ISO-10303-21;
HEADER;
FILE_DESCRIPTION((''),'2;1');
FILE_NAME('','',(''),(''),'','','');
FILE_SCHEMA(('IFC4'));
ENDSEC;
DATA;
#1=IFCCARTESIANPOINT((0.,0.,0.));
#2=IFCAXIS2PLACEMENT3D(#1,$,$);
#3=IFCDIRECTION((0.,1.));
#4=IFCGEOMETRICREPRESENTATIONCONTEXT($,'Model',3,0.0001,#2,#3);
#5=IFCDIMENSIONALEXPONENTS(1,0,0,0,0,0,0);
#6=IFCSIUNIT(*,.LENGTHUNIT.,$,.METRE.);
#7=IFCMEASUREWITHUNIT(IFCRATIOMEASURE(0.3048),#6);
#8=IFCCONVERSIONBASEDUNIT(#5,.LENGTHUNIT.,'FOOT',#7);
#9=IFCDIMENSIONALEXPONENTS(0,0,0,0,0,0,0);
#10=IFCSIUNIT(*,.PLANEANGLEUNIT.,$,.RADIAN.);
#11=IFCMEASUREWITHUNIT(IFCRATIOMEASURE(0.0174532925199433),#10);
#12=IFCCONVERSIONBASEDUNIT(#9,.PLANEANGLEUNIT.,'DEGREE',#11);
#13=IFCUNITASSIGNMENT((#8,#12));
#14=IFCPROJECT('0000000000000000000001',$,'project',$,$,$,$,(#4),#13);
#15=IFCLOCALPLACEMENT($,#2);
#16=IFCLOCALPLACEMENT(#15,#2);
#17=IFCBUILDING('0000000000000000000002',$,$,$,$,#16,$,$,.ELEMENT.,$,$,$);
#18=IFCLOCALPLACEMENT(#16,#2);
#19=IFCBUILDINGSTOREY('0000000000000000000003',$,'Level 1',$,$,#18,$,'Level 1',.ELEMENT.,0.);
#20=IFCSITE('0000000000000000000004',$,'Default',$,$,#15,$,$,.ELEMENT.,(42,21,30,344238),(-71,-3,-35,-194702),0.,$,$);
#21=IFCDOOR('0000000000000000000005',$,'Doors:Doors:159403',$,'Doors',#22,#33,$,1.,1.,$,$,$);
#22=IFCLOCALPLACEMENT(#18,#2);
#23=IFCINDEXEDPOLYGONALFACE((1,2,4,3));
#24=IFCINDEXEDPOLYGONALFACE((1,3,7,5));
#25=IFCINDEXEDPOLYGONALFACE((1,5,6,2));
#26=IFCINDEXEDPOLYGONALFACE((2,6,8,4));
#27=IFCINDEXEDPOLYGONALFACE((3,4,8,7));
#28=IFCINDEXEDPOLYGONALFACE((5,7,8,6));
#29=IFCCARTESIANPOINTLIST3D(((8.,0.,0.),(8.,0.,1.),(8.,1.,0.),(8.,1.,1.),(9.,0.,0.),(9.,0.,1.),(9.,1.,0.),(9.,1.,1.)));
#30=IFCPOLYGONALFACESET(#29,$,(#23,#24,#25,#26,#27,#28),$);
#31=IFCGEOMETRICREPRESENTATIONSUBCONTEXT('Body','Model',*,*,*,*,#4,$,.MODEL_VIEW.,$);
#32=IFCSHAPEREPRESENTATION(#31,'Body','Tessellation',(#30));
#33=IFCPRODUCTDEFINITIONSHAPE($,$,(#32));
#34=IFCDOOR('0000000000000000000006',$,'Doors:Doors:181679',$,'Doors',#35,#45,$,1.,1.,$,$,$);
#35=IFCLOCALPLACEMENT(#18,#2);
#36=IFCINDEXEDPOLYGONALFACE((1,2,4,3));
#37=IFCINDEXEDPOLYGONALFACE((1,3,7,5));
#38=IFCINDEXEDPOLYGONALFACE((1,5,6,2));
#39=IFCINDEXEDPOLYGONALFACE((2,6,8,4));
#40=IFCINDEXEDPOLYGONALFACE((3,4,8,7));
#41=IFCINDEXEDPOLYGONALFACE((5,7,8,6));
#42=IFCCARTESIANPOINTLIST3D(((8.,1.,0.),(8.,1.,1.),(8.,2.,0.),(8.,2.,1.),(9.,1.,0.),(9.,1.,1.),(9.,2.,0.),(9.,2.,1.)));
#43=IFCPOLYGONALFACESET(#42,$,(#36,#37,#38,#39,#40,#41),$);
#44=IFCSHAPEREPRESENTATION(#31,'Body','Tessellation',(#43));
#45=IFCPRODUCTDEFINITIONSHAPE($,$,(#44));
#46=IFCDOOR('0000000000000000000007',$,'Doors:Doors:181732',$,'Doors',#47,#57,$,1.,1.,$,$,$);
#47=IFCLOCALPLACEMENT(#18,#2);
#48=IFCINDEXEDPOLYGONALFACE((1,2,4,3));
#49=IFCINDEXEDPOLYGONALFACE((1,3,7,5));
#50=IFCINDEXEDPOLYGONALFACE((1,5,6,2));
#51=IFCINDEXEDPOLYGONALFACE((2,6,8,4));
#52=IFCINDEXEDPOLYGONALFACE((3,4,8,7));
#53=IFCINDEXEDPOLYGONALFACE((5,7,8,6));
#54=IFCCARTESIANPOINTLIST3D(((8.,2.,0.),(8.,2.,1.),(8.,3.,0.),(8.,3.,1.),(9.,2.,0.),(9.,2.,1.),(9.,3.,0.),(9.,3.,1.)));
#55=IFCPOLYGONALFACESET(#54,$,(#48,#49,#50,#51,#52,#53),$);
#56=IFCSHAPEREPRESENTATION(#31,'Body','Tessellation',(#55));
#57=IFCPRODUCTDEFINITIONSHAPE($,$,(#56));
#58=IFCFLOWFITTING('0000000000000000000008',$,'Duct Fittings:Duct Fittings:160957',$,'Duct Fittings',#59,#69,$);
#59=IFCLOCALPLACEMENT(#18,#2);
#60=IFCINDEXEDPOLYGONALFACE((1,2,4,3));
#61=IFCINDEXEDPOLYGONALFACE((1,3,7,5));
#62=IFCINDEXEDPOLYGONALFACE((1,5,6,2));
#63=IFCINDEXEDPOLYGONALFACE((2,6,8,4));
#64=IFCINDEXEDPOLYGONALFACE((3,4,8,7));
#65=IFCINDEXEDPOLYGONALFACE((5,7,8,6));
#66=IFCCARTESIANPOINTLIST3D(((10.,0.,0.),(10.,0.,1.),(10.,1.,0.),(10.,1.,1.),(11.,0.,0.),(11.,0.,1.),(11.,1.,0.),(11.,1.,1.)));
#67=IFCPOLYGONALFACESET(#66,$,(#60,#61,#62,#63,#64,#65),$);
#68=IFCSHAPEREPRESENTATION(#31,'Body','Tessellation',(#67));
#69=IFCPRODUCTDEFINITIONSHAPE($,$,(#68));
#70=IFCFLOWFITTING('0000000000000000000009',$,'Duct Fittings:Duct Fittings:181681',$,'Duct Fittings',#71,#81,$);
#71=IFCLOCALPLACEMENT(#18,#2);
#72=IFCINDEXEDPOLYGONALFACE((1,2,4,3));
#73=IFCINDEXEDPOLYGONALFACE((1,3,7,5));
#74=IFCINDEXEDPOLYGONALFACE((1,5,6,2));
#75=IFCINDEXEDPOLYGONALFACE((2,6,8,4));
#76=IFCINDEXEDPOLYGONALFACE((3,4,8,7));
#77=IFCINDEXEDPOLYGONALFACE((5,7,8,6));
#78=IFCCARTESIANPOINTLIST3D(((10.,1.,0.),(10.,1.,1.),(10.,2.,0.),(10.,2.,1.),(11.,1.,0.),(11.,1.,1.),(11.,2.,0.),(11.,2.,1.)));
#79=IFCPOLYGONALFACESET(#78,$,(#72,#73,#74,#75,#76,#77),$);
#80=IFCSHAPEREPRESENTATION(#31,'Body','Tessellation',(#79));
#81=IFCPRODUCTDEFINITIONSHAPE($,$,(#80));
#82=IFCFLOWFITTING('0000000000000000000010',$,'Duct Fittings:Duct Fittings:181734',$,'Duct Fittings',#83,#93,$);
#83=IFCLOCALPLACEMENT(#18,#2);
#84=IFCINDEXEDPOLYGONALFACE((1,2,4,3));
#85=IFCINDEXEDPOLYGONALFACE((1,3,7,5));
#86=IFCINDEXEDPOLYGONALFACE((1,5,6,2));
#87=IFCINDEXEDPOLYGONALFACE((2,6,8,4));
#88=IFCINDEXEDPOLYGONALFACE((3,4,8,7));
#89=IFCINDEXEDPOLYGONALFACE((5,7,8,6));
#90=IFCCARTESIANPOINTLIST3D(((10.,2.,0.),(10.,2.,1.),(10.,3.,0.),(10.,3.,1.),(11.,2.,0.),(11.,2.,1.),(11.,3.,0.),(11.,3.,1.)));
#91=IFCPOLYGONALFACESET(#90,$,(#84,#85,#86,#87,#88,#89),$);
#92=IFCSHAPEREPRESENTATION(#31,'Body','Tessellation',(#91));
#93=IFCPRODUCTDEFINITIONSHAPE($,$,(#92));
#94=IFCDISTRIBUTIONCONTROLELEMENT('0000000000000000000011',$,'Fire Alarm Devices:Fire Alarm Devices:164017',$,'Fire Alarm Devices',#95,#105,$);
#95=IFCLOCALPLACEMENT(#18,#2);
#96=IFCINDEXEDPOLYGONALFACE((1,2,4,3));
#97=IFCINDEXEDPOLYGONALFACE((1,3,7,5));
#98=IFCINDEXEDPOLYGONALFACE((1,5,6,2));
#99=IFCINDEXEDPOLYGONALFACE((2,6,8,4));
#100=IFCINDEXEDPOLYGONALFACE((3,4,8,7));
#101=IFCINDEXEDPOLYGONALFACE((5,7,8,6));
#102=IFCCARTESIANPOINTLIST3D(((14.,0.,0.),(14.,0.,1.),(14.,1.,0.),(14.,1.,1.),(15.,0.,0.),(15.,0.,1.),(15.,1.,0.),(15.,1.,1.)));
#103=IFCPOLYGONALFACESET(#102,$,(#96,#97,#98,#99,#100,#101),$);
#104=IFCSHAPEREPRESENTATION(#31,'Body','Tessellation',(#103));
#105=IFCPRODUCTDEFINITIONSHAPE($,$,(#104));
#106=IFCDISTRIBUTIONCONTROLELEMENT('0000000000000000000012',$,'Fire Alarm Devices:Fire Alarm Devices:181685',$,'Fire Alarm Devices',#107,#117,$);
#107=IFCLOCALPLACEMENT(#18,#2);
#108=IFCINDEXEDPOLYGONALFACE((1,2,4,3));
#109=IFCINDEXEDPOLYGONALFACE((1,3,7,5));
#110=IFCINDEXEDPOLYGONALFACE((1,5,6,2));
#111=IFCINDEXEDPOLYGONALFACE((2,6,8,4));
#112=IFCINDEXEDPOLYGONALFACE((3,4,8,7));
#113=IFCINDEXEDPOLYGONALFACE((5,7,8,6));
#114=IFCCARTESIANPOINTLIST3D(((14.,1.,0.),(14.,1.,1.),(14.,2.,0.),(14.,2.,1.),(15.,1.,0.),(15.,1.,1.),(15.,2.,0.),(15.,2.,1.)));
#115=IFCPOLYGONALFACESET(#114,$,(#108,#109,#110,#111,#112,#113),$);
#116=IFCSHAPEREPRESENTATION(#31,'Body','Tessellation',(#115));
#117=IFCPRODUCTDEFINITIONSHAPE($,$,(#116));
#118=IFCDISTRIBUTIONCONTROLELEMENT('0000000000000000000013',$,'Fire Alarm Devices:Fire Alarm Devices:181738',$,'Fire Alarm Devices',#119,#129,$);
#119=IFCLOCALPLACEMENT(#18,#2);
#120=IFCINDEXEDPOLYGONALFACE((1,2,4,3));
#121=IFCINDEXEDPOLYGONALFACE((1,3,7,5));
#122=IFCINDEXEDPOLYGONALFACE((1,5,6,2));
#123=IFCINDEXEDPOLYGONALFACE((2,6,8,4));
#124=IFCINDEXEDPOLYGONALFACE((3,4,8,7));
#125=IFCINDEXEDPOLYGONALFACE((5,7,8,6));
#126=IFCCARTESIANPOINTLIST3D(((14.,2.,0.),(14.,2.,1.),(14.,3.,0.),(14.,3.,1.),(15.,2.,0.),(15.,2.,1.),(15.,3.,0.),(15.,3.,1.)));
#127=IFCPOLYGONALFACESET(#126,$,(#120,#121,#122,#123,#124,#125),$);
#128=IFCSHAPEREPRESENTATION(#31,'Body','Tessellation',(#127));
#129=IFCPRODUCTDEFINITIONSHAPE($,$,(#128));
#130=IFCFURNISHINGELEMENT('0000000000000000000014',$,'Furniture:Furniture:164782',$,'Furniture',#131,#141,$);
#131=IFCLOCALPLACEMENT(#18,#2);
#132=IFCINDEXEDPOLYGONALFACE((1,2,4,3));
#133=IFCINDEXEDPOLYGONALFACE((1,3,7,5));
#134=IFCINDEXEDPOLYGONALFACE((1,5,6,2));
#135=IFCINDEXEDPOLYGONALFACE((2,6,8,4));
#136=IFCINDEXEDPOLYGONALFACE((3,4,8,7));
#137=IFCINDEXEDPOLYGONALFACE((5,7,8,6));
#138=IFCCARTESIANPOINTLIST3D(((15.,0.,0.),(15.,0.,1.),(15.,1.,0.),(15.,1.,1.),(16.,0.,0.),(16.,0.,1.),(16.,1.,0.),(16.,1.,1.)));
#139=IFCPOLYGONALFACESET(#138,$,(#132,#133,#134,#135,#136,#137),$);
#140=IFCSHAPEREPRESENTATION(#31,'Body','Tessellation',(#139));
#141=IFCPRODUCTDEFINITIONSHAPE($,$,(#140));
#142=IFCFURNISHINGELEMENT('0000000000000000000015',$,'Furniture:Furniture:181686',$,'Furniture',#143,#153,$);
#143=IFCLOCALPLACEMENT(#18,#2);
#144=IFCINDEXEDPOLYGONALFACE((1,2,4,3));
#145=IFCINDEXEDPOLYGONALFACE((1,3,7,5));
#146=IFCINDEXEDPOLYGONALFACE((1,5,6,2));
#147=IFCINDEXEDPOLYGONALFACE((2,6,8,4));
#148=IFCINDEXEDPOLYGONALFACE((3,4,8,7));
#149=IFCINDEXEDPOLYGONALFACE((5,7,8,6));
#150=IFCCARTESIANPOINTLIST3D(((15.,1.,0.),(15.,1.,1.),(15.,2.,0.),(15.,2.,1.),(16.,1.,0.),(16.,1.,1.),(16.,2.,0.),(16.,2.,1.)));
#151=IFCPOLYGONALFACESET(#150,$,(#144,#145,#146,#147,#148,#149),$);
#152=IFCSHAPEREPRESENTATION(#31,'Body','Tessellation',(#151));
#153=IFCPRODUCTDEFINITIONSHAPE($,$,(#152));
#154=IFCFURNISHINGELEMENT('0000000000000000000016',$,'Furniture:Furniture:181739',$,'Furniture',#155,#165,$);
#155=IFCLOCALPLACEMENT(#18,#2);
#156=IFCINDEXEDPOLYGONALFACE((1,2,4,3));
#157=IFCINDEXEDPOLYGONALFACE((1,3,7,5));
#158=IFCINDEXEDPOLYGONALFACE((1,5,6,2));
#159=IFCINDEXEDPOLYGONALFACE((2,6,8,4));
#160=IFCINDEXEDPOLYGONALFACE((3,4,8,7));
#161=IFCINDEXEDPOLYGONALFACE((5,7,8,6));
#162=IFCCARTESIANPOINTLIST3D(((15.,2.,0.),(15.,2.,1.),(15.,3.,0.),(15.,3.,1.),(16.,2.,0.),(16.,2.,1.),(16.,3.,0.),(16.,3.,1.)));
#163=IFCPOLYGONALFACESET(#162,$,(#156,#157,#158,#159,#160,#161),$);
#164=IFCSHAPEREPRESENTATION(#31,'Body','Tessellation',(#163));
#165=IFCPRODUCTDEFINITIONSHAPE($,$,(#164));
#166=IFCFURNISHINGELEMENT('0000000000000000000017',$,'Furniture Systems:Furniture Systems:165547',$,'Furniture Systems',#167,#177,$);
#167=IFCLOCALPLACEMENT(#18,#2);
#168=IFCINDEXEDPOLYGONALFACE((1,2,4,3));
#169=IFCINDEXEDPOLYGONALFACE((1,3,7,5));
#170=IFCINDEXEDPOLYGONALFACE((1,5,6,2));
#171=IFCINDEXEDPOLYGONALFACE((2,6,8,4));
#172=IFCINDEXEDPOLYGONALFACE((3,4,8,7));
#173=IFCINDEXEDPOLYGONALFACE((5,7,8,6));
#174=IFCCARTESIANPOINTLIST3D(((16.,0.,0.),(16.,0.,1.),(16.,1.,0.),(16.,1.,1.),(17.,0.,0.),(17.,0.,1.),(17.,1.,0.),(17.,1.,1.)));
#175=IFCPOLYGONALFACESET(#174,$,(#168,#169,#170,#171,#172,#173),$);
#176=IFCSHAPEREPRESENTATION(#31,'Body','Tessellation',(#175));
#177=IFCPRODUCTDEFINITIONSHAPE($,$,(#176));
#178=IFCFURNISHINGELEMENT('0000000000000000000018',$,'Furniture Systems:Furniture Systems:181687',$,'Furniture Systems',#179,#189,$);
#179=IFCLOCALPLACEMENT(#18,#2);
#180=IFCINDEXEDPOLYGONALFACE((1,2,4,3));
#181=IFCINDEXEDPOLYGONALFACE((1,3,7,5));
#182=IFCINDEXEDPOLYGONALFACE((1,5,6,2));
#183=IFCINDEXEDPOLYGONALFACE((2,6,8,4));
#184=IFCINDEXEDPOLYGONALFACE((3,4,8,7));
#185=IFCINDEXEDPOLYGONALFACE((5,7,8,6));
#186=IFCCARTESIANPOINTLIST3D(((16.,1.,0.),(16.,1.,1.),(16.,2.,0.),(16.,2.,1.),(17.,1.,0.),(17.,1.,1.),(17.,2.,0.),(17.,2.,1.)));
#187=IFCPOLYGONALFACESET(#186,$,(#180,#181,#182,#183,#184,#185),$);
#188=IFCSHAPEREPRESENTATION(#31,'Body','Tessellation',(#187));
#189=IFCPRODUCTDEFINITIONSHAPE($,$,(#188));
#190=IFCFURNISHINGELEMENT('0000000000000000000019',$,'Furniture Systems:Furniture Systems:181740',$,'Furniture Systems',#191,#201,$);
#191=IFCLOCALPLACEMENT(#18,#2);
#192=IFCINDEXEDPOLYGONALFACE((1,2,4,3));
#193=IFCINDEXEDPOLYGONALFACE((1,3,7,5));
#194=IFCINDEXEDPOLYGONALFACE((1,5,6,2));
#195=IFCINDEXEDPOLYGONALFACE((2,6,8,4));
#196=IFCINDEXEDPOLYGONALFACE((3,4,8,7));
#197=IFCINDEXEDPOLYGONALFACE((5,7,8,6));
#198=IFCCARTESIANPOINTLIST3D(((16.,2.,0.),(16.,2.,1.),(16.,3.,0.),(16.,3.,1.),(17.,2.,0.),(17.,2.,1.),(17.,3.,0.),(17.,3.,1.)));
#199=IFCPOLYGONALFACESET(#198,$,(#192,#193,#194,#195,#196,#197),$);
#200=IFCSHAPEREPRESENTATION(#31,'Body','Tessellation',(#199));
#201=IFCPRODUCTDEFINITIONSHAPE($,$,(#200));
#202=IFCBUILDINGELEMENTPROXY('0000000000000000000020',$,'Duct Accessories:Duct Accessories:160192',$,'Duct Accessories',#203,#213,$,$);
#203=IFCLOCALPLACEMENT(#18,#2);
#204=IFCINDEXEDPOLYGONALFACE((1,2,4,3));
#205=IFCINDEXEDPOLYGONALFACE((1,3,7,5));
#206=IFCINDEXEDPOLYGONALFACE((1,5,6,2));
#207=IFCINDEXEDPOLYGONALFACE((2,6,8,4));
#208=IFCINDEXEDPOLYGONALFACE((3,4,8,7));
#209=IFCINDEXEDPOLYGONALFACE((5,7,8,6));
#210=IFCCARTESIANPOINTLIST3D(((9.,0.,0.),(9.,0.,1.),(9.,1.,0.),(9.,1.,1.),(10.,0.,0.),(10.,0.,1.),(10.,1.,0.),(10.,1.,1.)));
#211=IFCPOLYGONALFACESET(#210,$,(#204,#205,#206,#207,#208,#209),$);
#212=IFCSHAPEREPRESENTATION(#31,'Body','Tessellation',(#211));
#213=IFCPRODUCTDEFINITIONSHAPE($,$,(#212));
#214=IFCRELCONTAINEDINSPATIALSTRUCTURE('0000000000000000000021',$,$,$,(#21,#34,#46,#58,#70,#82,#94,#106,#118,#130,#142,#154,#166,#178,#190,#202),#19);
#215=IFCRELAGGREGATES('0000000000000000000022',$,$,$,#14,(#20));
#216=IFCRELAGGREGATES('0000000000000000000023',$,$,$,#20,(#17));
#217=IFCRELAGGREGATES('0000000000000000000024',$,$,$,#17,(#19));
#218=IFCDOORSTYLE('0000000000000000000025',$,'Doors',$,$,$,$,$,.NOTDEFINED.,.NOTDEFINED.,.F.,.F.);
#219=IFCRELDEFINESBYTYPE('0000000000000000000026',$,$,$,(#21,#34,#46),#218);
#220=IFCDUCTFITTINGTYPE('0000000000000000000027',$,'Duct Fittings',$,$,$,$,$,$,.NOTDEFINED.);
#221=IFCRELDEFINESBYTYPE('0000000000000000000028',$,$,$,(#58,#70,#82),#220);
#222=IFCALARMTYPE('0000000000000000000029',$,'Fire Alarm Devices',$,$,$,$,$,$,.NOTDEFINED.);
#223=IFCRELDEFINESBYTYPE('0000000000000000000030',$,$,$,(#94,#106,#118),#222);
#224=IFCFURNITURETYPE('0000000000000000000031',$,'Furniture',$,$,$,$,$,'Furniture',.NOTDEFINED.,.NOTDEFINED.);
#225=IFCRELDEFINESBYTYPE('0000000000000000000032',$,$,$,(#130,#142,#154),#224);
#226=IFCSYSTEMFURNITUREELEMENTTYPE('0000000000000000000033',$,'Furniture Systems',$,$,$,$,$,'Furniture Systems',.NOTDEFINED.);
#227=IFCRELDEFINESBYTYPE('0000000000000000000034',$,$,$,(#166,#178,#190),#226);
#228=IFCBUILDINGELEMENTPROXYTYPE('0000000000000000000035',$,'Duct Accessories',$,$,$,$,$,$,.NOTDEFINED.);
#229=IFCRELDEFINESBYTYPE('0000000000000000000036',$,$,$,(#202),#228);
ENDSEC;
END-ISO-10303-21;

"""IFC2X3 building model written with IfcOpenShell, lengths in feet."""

from ifc_helpers import new_model, entity, si_unit, converted_unit, direction, frame, frame_2d, origin, place, context, subcontext, project, spatial, rectangle, extrude, source, transform, mapped, type_object, type_shapes, element, save


model = new_model("IFC2X3")

# Units and contexts
model_context = context("Model", 3, precision=0.0001, world=origin(), true_north=direction((0.0, 1.0)))
body_context = subcontext(model_context, "Body", "Model", "MODEL_VIEW")
ifc_project = project(units=[converted_unit("LENGTHUNIT", "FOOT", entity("IfcRatioMeasure", 0.3048), si_unit("LENGTHUNIT", "METRE"), dimensions=[1, 0, 0, 0, 0, 0, 0]), converted_unit("PLANEANGLEUNIT", "DEGREE", entity("IfcRatioMeasure", 0.0174532925199433), si_unit("PLANEANGLEUNIT", "RADIAN"), dimensions=[0, 0, 0, 0, 0, 0, 0])], contexts=[model_context])

# Site, building, storey
site_placement = place(None, origin())
site = spatial("IfcSite", under=ifc_project, at=site_placement, Name="Default", CompositionType="ELEMENT", RefLatitude=(42, 21, 30, 344238), RefLongitude=(-71, -3, -35, -194702), RefElevation=0.0)
building_placement = place(site_placement, origin())
building = spatial("IfcBuilding", under=site, at=building_placement, CompositionType="ELEMENT")
storey_placement = place(building_placement, origin())
storey = spatial("IfcBuildingStorey", under=building, at=storey_placement, Name="Level 1", LongName="Level 1", CompositionType="ELEMENT", Elevation=0.0)

# Doors
door_style = type_object("IfcDoorStyle", Name="Doors", ConstructionType="NOTDEFINED", OperationType="NOTDEFINED", ParameterTakesPrecedence=False, Sizeable=False)
shared_shape_1 = source(origin(), body_context, "Body", "SweptSolid", [
    extrude(rectangle(XDim=1.0, YDim=1.0, at=frame_2d((0.0, 0.0), x_axis=(1.0, 0.0))), frame((0.5, 0.5, 0.0), z_axis=(0.0, 0.0, 1.0), x_axis=(0.0, 1.0, 0.0)), (0.0, 0.0, 1.0), 1.0),
])
type_shapes(door_style, [shared_shape_1])
for number, where, name in (
    (1, (8.0, 0.0, 0.0), "Doors:Doors:159403"),
    (2, (8.0, 1.0, 0.0), "Doors:Doors:181679"),
    (3, (8.0, 2.0, 0.0), "Doors:Doors:181732"),
):
    element("IfcDoor", number, at=place(storey_placement, frame(where)), inside=storey, type_object=door_style, Name=name, ObjectType="Doors", OverallHeight=1.0, OverallWidth=1.0, context=body_context, shape_type="MappedRepresentation", body=[
        mapped(shared_shape_1, transform((0.0, 0.0, 0.0), scale=1.0)),
    ])

# Flow fittings
duct_fitting_type = type_object("IfcDuctFittingType", Name="Duct Fittings", PredefinedType="NOTDEFINED")
shared_shape_2 = source(origin(), body_context, "Body", "SweptSolid", [
    extrude(rectangle(XDim=1.0, YDim=1.0, at=frame_2d((0.0, 0.0), x_axis=(1.0, 0.0))), frame((0.5, 0.5, 0.0), z_axis=(0.0, 0.0, 1.0), x_axis=(0.0, 1.0, 0.0)), (0.0, 0.0, 1.0), 1.0),
])
type_shapes(duct_fitting_type, [shared_shape_2])
for number, where, name in (
    (4, (10.0, 0.0, 0.0), "Duct Fittings:Duct Fittings:160957"),
    (5, (10.0, 1.0, 0.0), "Duct Fittings:Duct Fittings:181681"),
    (6, (10.0, 2.0, 0.0), "Duct Fittings:Duct Fittings:181734"),
):
    element("IfcFlowFitting", number, at=place(storey_placement, frame(where)), inside=storey, type_object=duct_fitting_type, Name=name, ObjectType="Duct Fittings", context=body_context, shape_type="MappedRepresentation", body=[
        mapped(shared_shape_2, transform((0.0, 0.0, 0.0), scale=1.0)),
    ])

# Distribution control elements
alarm_type = type_object("IfcAlarmType", Name="Fire Alarm Devices", PredefinedType="NOTDEFINED")
shared_shape_3 = source(origin(), body_context, "Body", "SweptSolid", [
    extrude(rectangle(XDim=1.0, YDim=1.0, at=frame_2d((0.0, 0.0), x_axis=(1.0, 0.0))), frame((0.5, 0.5, 0.0), z_axis=(0.0, 0.0, 1.0), x_axis=(0.0, 1.0, 0.0)), (0.0, 0.0, 1.0), 1.0),
])
type_shapes(alarm_type, [shared_shape_3])
for number, where, name in (
    (7, (14.0, 0.0, 0.0), "Fire Alarm Devices:Fire Alarm Devices:164017"),
    (8, (14.0, 1.0, 0.0), "Fire Alarm Devices:Fire Alarm Devices:181685"),
    (9, (14.0, 2.0, 0.0), "Fire Alarm Devices:Fire Alarm Devices:181738"),
):
    element("IfcDistributionControlElement", number, at=place(storey_placement, frame(where)), inside=storey, type_object=alarm_type, Name=name, ObjectType="Fire Alarm Devices", context=body_context, shape_type="MappedRepresentation", body=[
        mapped(shared_shape_3, transform((0.0, 0.0, 0.0), scale=1.0)),
    ])

# Furnishing elements
furniture_type = type_object("IfcFurnitureType", Name="Furniture", ElementType="Furniture")
shared_shape_4 = source(origin(), body_context, "Body", "SweptSolid", [
    extrude(rectangle(XDim=1.0, YDim=1.0, at=frame_2d((0.0, 0.0), x_axis=(1.0, 0.0))), frame((0.5, 0.5, 0.0), z_axis=(0.0, 0.0, 1.0), x_axis=(0.0, 1.0, 0.0)), (0.0, 0.0, 1.0), 1.0),
])
type_shapes(furniture_type, [shared_shape_4])
for number, where, name in (
    (10, (15.0, 0.0, 0.0), "Furniture:Furniture:164782"),
    (11, (15.0, 1.0, 0.0), "Furniture:Furniture:181686"),
    (12, (15.0, 2.0, 0.0), "Furniture:Furniture:181739"),
):
    element("IfcFurnishingElement", number, at=place(storey_placement, frame(where)), inside=storey, type_object=furniture_type, Name=name, ObjectType="Furniture", context=body_context, shape_type="MappedRepresentation", body=[
        mapped(shared_shape_4, transform((0.0, 0.0, 0.0), scale=1.0)),
    ])
system_furniture_element_type = type_object("IfcSystemFurnitureElementType", Name="Furniture Systems", ElementType="Furniture Systems")
shared_shape_5 = source(origin(), body_context, "Body", "SweptSolid", [
    extrude(rectangle(XDim=1.0, YDim=1.0, at=frame_2d((0.0, 0.0), x_axis=(1.0, 0.0))), frame((0.5, 0.5, 0.0), z_axis=(0.0, 0.0, 1.0), x_axis=(0.0, 1.0, 0.0)), (0.0, 0.0, 1.0), 1.0),
])
type_shapes(system_furniture_element_type, [shared_shape_5])
for number, where, name in (
    (13, (16.0, 0.0, 0.0), "Furniture Systems:Furniture Systems:165547"),
    (14, (16.0, 1.0, 0.0), "Furniture Systems:Furniture Systems:181687"),
    (15, (16.0, 2.0, 0.0), "Furniture Systems:Furniture Systems:181740"),
):
    element("IfcFurnishingElement", number, at=place(storey_placement, frame(where)), inside=storey, type_object=system_furniture_element_type, Name=name, ObjectType="Furniture Systems", context=body_context, shape_type="MappedRepresentation", body=[
        mapped(shared_shape_5, transform((0.0, 0.0, 0.0), scale=1.0)),
    ])

# Building element proxy
building_element_proxy_type_1 = type_object("IfcBuildingElementProxyType", Name="Duct Accessories", PredefinedType="NOTDEFINED")
shared_shape_6 = source(origin(), body_context, "Body", "SweptSolid", [
    extrude(rectangle(XDim=1.0, YDim=1.0, at=frame_2d((0.0, 0.0), x_axis=(1.0, 0.0))), frame((0.5, 0.5, 0.0), z_axis=(0.0, 0.0, 1.0), x_axis=(0.0, 1.0, 0.0)), (0.0, 0.0, 1.0), 1.0),
])
type_shapes(building_element_proxy_type_1, [shared_shape_6])
for number, where, name in (
    (16, (9.0, 0.0, 0.0), "Duct Accessories:Duct Accessories:160192"),
):
    element("IfcBuildingElementProxy", number, at=place(storey_placement, frame(where)), inside=storey, type_object=building_element_proxy_type_1, Name=name, ObjectType="Duct Accessories", context=body_context, shape_type="MappedRepresentation", body=[
        mapped(shared_shape_6, transform((0.0, 0.0, 0.0), scale=1.0)),
    ])

save(model, "model.ifc")
